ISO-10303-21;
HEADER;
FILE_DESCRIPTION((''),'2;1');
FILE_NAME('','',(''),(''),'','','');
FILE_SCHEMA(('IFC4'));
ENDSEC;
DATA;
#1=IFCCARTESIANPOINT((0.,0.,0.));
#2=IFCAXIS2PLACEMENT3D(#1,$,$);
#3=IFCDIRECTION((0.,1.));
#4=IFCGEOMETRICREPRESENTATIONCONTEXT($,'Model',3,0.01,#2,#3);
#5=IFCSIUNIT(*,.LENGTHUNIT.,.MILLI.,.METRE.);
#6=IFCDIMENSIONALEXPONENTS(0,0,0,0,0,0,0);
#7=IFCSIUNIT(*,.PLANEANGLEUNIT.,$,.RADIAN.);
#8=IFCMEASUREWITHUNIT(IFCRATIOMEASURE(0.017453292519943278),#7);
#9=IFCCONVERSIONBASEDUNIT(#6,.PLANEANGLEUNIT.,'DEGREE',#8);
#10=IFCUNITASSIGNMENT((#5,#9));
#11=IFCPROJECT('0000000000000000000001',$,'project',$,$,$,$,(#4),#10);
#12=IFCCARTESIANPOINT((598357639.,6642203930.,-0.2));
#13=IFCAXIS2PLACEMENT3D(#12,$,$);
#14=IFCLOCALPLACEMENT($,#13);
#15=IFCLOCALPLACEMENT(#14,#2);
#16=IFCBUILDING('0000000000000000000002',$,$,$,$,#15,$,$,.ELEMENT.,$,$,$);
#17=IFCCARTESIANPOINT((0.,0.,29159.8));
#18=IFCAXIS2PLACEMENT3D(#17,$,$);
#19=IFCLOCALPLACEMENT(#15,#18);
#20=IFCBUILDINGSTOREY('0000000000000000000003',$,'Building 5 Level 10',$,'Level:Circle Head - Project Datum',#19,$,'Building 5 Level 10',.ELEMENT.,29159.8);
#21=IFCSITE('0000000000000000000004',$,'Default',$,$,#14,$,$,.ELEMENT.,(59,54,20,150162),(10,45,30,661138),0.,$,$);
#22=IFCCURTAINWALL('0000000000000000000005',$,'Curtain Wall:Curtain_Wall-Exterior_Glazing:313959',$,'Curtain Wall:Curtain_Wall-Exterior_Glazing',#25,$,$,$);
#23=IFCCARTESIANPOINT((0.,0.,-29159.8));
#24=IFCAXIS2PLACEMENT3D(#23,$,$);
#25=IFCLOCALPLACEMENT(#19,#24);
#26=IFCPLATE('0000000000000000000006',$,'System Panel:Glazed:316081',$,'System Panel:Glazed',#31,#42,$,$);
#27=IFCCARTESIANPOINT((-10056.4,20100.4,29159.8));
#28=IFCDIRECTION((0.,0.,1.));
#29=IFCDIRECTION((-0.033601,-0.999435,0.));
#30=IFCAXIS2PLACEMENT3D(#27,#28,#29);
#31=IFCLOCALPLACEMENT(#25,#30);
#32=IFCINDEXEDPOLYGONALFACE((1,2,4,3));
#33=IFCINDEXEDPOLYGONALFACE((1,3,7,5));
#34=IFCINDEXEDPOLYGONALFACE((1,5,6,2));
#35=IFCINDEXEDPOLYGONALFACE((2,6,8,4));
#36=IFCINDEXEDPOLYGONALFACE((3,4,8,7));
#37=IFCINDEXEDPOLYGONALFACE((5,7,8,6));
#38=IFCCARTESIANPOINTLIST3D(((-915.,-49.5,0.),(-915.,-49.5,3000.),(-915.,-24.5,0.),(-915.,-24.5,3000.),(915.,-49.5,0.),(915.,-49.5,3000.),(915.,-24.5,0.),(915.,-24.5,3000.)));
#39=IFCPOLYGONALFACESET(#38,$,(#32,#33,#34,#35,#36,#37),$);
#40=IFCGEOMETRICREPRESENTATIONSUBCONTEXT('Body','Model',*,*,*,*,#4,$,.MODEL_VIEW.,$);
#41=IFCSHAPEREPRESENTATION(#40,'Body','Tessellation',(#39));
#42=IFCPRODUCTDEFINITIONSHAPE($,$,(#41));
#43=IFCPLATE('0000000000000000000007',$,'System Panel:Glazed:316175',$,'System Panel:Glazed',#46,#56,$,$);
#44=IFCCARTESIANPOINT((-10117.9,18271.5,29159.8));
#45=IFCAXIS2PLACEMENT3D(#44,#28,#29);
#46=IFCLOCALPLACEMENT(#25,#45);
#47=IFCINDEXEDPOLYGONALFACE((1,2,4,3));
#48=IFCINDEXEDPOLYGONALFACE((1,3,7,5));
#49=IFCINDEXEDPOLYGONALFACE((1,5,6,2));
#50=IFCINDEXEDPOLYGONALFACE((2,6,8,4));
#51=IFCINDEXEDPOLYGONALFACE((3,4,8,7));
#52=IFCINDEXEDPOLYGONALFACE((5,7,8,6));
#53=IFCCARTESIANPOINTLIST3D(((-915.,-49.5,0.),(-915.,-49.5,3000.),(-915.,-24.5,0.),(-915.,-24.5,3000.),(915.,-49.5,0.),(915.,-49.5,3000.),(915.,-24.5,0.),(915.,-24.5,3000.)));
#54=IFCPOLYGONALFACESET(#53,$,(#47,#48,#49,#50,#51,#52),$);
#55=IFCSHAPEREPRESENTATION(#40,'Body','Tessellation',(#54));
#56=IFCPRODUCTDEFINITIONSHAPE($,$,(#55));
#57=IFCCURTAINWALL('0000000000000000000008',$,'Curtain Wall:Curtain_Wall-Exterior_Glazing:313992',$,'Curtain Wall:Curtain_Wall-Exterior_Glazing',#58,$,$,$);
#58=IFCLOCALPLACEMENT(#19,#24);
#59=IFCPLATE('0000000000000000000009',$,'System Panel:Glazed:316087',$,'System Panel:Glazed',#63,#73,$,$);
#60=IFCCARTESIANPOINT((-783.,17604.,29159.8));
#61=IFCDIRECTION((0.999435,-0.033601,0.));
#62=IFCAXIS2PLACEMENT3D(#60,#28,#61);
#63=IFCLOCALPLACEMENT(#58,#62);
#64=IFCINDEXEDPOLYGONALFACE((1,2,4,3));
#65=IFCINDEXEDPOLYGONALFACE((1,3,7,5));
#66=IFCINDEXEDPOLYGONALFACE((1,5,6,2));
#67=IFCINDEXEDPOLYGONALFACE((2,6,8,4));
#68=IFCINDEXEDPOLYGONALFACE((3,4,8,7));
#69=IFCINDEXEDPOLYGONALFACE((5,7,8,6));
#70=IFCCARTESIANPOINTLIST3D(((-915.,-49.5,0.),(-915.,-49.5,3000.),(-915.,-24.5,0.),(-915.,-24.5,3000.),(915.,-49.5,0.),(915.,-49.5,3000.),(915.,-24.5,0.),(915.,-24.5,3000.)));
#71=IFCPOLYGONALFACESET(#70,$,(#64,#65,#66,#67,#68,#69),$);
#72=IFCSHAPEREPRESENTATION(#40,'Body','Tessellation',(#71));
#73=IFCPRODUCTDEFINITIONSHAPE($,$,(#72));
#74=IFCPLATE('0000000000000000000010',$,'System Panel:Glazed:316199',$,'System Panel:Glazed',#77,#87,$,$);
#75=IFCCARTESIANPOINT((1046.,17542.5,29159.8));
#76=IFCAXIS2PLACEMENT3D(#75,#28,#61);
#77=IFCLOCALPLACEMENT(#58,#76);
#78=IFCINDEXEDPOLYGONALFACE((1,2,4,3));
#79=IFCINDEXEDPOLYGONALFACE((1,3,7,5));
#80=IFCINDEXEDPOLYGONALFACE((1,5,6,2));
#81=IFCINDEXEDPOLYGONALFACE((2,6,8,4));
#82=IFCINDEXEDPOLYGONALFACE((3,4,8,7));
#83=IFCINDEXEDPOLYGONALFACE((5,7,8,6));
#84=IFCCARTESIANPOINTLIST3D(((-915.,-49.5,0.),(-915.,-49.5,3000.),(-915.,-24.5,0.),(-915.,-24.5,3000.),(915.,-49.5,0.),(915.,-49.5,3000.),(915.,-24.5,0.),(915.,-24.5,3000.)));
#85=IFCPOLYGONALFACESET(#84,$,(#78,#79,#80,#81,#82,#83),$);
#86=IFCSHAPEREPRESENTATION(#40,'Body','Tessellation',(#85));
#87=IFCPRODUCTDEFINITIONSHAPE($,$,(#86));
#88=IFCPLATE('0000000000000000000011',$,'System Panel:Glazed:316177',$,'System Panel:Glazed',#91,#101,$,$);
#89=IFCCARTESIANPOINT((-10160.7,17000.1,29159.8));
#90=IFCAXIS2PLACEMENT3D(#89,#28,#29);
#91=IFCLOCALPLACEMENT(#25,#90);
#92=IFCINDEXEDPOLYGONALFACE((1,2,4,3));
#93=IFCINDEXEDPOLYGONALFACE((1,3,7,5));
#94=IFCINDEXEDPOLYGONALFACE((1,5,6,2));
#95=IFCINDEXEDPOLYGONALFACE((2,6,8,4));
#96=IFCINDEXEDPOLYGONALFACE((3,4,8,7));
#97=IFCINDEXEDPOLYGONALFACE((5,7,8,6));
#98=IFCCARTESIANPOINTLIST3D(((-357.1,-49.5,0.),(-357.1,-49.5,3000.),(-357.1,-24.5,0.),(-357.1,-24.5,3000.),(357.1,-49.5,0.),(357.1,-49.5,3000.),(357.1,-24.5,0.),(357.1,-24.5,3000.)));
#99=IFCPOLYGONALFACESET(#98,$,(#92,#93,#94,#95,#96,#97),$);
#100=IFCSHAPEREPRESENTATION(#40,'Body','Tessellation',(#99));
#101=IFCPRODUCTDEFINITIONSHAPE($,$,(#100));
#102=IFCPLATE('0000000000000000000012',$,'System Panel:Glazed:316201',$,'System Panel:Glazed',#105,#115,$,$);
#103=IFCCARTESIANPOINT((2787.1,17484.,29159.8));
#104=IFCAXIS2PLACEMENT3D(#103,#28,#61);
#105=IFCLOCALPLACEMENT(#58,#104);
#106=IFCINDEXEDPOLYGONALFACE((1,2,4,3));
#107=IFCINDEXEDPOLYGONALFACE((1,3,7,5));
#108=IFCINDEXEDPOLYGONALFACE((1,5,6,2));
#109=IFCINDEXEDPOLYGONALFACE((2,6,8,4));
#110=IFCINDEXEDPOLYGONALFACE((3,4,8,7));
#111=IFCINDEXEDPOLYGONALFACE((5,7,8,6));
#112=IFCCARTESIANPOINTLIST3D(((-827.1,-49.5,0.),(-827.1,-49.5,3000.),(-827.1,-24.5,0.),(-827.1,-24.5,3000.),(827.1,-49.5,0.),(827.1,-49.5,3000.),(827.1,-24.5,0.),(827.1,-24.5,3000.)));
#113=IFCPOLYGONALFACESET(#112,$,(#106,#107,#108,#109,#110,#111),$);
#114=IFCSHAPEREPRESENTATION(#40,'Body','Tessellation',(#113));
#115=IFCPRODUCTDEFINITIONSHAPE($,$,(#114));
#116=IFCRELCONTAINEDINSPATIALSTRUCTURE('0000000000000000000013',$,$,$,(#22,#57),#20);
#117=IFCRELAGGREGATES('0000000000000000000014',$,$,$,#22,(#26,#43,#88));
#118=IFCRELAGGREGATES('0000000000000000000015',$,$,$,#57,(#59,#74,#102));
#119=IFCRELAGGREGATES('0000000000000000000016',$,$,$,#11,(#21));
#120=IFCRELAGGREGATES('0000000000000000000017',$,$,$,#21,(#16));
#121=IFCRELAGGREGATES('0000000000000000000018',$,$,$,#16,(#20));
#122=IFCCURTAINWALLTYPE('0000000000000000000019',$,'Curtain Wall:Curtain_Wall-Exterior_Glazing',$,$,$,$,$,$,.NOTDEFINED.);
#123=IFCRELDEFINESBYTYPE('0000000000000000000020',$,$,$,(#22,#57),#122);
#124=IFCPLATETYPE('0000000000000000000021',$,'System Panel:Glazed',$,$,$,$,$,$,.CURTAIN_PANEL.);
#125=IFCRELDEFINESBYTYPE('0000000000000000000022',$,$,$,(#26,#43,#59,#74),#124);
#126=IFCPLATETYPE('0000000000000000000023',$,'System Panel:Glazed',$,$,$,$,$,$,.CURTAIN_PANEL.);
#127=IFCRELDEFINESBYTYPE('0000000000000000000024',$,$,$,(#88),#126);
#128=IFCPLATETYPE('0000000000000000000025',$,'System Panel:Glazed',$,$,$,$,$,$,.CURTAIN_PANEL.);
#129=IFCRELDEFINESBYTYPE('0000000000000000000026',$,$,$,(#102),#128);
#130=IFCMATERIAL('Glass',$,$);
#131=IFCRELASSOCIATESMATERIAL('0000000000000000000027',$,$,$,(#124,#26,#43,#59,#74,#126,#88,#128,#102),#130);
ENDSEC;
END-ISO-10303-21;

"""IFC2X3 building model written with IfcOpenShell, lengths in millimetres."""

from ifc_helpers import new_model, entity, si_unit, converted_unit, direction, frame, frame_2d, origin, place, context, subcontext, project, spatial, rectangle, extrude, source, transform, mapped, material, type_object, type_shapes, element, aggregate, save


model = new_model("IFC2X3")

# Units and contexts
model_context = context("Model", 3, precision=0.01, world=origin(), true_north=direction((0.0, 1.0)))
body_context = subcontext(model_context, "Body", "Model", "MODEL_VIEW")
ifc_project = project(units=[si_unit("LENGTHUNIT", "METRE", prefix="MILLI"), converted_unit("PLANEANGLEUNIT", "DEGREE", entity("IfcRatioMeasure", 0.017453292519943278), si_unit("PLANEANGLEUNIT", "RADIAN"), dimensions=[0, 0, 0, 0, 0, 0, 0])], contexts=[model_context])

# Site, building, storey
site_placement = place(None, frame((598357639.0, 6642203930.0, -0.2)))
site = spatial("IfcSite", under=ifc_project, at=site_placement, Name="Default", CompositionType="ELEMENT", RefLatitude=(59, 54, 20, 150162), RefLongitude=(10, 45, 30, 661138), RefElevation=0.0)
building_placement = place(site_placement, origin())
building = spatial("IfcBuilding", under=site, at=building_placement, CompositionType="ELEMENT")
storey_placement = place(building_placement, frame((0.0, 0.0, 29159.8)))
storey = spatial("IfcBuildingStorey", under=building, at=storey_placement, Name="Building 5 Level 10", ObjectType="Level:Circle Head - Project Datum", LongName="Building 5 Level 10", CompositionType="ELEMENT", Elevation=29159.8)

# Curtain walls, plates
curtain_wall_type = type_object("IfcCurtainWallType", Name="Curtain Wall:Curtain_Wall-Exterior_Glazing", PredefinedType="NOTDEFINED")
curtain_wall_1_placement = place(storey_placement, frame((0.0, 0.0, -29159.8)))
curtain_wall_1 = element("IfcCurtainWall", 1, at=curtain_wall_1_placement, inside=storey, type_object=curtain_wall_type, Name="Curtain Wall:Curtain_Wall-Exterior_Glazing:313959", ObjectType="Curtain Wall:Curtain_Wall-Exterior_Glazing")
ifc_material_1 = material(Name="Glass")
plate_type_1 = type_object("IfcPlateType", Name="System Panel:Glazed", PredefinedType="CURTAIN_PANEL", material=ifc_material_1)
shared_shape_1 = source(origin(), body_context, "Body", "SweptSolid", [
    extrude(rectangle(XDim=25.0, YDim=1830.0, at=frame_2d((0.0, 0.0), x_axis=(1.0, 0.0))), frame((0.0, -37.0, 0.0), z_axis=(0.0, 0.0, 1.0), x_axis=(0.0, 1.0, 0.0)), (0.0, 0.0, 1.0), 3000.0),
])
type_shapes(plate_type_1, [shared_shape_1])
plate_1_placement = place(curtain_wall_1_placement, frame((-10056.4, 20100.4, 29159.8), z_axis=(0.0, 0.0, 1.0), x_axis=(-0.033601, -0.999435, 0.0)))
plate_1 = element("IfcPlate", 2, at=plate_1_placement, type_object=plate_type_1, material=ifc_material_1, Name="System Panel:Glazed:316081", ObjectType="System Panel:Glazed", context=body_context, shape_type="MappedRepresentation", body=[
    mapped(shared_shape_1, transform((0.0, 0.0, 0.0), scale=1.0)),
])
plate_2_placement = place(curtain_wall_1_placement, frame((-10117.9, 18271.5, 29159.8), z_axis=(0.0, 0.0, 1.0), x_axis=(-0.033601, -0.999435, 0.0)))
plate_2 = element("IfcPlate", 3, at=plate_2_placement, type_object=plate_type_1, material=ifc_material_1, Name="System Panel:Glazed:316175", ObjectType="System Panel:Glazed", context=body_context, shape_type="MappedRepresentation", body=[
    mapped(shared_shape_1, transform((0.0, 0.0, 0.0), scale=1.0)),
])
curtain_wall_2_placement = place(storey_placement, frame((0.0, 0.0, -29159.8)))
curtain_wall_2 = element("IfcCurtainWall", 4, at=curtain_wall_2_placement, inside=storey, type_object=curtain_wall_type, Name="Curtain Wall:Curtain_Wall-Exterior_Glazing:313992", ObjectType="Curtain Wall:Curtain_Wall-Exterior_Glazing")
plate_3_placement = place(curtain_wall_2_placement, frame((-783.0, 17604.0, 29159.8), z_axis=(0.0, 0.0, 1.0), x_axis=(0.999435, -0.033601, 0.0)))
plate_3 = element("IfcPlate", 5, at=plate_3_placement, type_object=plate_type_1, material=ifc_material_1, Name="System Panel:Glazed:316087", ObjectType="System Panel:Glazed", context=body_context, shape_type="MappedRepresentation", body=[
    mapped(shared_shape_1, transform((0.0, 0.0, 0.0), scale=1.0)),
])
plate_4_placement = place(curtain_wall_2_placement, frame((1046.0, 17542.5, 29159.8), z_axis=(0.0, 0.0, 1.0), x_axis=(0.999435, -0.033601, 0.0)))
plate_4 = element("IfcPlate", 6, at=plate_4_placement, type_object=plate_type_1, material=ifc_material_1, Name="System Panel:Glazed:316199", ObjectType="System Panel:Glazed", context=body_context, shape_type="MappedRepresentation", body=[
    mapped(shared_shape_1, transform((0.0, 0.0, 0.0), scale=1.0)),
])

# Plates
plate_type_2 = type_object("IfcPlateType", Name="System Panel:Glazed", PredefinedType="CURTAIN_PANEL", material=ifc_material_1)
shared_shape_2 = source(origin(), body_context, "Body", "SweptSolid", [
    extrude(rectangle(XDim=25.0, YDim=714.2, at=frame_2d((0.0, 0.0), x_axis=(1.0, 0.0))), frame((0.0, -37.0, 0.0), z_axis=(0.0, 0.0, 1.0), x_axis=(0.0, 1.0, 0.0)), (0.0, 0.0, 1.0), 3000.0),
])
type_shapes(plate_type_2, [shared_shape_2])
plate_5_placement = place(curtain_wall_1_placement, frame((-10160.7, 17000.1, 29159.8), z_axis=(0.0, 0.0, 1.0), x_axis=(-0.033601, -0.999435, 0.0)))
plate_5 = element("IfcPlate", 7, at=plate_5_placement, type_object=plate_type_2, material=ifc_material_1, Name="System Panel:Glazed:316177", ObjectType="System Panel:Glazed", context=body_context, shape_type="MappedRepresentation", body=[
    mapped(shared_shape_2, transform((0.0, 0.0, 0.0), scale=1.0)),
])
aggregate(curtain_wall_1, [plate_1, plate_2, plate_5])
plate_type_3 = type_object("IfcPlateType", Name="System Panel:Glazed", PredefinedType="CURTAIN_PANEL", material=ifc_material_1)
shared_shape_3 = source(origin(), body_context, "Body", "SweptSolid", [
    extrude(rectangle(XDim=25.0, YDim=1654.3, at=frame_2d((0.0, 0.0), x_axis=(1.0, 0.0))), frame((0.0, -37.0, 0.0), z_axis=(0.0, 0.0, 1.0), x_axis=(0.0, 1.0, 0.0)), (0.0, 0.0, 1.0), 3000.0),
])
type_shapes(plate_type_3, [shared_shape_3])
plate_6_placement = place(curtain_wall_2_placement, frame((2787.1, 17484.0, 29159.8), z_axis=(0.0, 0.0, 1.0), x_axis=(0.999435, -0.033601, 0.0)))
plate_6 = element("IfcPlate", 8, at=plate_6_placement, type_object=plate_type_3, material=ifc_material_1, Name="System Panel:Glazed:316201", ObjectType="System Panel:Glazed", context=body_context, shape_type="MappedRepresentation", body=[
    mapped(shared_shape_3, transform((0.0, 0.0, 0.0), scale=1.0)),
])
aggregate(curtain_wall_2, [plate_3, plate_4, plate_6])

save(model, "model.ifc")
